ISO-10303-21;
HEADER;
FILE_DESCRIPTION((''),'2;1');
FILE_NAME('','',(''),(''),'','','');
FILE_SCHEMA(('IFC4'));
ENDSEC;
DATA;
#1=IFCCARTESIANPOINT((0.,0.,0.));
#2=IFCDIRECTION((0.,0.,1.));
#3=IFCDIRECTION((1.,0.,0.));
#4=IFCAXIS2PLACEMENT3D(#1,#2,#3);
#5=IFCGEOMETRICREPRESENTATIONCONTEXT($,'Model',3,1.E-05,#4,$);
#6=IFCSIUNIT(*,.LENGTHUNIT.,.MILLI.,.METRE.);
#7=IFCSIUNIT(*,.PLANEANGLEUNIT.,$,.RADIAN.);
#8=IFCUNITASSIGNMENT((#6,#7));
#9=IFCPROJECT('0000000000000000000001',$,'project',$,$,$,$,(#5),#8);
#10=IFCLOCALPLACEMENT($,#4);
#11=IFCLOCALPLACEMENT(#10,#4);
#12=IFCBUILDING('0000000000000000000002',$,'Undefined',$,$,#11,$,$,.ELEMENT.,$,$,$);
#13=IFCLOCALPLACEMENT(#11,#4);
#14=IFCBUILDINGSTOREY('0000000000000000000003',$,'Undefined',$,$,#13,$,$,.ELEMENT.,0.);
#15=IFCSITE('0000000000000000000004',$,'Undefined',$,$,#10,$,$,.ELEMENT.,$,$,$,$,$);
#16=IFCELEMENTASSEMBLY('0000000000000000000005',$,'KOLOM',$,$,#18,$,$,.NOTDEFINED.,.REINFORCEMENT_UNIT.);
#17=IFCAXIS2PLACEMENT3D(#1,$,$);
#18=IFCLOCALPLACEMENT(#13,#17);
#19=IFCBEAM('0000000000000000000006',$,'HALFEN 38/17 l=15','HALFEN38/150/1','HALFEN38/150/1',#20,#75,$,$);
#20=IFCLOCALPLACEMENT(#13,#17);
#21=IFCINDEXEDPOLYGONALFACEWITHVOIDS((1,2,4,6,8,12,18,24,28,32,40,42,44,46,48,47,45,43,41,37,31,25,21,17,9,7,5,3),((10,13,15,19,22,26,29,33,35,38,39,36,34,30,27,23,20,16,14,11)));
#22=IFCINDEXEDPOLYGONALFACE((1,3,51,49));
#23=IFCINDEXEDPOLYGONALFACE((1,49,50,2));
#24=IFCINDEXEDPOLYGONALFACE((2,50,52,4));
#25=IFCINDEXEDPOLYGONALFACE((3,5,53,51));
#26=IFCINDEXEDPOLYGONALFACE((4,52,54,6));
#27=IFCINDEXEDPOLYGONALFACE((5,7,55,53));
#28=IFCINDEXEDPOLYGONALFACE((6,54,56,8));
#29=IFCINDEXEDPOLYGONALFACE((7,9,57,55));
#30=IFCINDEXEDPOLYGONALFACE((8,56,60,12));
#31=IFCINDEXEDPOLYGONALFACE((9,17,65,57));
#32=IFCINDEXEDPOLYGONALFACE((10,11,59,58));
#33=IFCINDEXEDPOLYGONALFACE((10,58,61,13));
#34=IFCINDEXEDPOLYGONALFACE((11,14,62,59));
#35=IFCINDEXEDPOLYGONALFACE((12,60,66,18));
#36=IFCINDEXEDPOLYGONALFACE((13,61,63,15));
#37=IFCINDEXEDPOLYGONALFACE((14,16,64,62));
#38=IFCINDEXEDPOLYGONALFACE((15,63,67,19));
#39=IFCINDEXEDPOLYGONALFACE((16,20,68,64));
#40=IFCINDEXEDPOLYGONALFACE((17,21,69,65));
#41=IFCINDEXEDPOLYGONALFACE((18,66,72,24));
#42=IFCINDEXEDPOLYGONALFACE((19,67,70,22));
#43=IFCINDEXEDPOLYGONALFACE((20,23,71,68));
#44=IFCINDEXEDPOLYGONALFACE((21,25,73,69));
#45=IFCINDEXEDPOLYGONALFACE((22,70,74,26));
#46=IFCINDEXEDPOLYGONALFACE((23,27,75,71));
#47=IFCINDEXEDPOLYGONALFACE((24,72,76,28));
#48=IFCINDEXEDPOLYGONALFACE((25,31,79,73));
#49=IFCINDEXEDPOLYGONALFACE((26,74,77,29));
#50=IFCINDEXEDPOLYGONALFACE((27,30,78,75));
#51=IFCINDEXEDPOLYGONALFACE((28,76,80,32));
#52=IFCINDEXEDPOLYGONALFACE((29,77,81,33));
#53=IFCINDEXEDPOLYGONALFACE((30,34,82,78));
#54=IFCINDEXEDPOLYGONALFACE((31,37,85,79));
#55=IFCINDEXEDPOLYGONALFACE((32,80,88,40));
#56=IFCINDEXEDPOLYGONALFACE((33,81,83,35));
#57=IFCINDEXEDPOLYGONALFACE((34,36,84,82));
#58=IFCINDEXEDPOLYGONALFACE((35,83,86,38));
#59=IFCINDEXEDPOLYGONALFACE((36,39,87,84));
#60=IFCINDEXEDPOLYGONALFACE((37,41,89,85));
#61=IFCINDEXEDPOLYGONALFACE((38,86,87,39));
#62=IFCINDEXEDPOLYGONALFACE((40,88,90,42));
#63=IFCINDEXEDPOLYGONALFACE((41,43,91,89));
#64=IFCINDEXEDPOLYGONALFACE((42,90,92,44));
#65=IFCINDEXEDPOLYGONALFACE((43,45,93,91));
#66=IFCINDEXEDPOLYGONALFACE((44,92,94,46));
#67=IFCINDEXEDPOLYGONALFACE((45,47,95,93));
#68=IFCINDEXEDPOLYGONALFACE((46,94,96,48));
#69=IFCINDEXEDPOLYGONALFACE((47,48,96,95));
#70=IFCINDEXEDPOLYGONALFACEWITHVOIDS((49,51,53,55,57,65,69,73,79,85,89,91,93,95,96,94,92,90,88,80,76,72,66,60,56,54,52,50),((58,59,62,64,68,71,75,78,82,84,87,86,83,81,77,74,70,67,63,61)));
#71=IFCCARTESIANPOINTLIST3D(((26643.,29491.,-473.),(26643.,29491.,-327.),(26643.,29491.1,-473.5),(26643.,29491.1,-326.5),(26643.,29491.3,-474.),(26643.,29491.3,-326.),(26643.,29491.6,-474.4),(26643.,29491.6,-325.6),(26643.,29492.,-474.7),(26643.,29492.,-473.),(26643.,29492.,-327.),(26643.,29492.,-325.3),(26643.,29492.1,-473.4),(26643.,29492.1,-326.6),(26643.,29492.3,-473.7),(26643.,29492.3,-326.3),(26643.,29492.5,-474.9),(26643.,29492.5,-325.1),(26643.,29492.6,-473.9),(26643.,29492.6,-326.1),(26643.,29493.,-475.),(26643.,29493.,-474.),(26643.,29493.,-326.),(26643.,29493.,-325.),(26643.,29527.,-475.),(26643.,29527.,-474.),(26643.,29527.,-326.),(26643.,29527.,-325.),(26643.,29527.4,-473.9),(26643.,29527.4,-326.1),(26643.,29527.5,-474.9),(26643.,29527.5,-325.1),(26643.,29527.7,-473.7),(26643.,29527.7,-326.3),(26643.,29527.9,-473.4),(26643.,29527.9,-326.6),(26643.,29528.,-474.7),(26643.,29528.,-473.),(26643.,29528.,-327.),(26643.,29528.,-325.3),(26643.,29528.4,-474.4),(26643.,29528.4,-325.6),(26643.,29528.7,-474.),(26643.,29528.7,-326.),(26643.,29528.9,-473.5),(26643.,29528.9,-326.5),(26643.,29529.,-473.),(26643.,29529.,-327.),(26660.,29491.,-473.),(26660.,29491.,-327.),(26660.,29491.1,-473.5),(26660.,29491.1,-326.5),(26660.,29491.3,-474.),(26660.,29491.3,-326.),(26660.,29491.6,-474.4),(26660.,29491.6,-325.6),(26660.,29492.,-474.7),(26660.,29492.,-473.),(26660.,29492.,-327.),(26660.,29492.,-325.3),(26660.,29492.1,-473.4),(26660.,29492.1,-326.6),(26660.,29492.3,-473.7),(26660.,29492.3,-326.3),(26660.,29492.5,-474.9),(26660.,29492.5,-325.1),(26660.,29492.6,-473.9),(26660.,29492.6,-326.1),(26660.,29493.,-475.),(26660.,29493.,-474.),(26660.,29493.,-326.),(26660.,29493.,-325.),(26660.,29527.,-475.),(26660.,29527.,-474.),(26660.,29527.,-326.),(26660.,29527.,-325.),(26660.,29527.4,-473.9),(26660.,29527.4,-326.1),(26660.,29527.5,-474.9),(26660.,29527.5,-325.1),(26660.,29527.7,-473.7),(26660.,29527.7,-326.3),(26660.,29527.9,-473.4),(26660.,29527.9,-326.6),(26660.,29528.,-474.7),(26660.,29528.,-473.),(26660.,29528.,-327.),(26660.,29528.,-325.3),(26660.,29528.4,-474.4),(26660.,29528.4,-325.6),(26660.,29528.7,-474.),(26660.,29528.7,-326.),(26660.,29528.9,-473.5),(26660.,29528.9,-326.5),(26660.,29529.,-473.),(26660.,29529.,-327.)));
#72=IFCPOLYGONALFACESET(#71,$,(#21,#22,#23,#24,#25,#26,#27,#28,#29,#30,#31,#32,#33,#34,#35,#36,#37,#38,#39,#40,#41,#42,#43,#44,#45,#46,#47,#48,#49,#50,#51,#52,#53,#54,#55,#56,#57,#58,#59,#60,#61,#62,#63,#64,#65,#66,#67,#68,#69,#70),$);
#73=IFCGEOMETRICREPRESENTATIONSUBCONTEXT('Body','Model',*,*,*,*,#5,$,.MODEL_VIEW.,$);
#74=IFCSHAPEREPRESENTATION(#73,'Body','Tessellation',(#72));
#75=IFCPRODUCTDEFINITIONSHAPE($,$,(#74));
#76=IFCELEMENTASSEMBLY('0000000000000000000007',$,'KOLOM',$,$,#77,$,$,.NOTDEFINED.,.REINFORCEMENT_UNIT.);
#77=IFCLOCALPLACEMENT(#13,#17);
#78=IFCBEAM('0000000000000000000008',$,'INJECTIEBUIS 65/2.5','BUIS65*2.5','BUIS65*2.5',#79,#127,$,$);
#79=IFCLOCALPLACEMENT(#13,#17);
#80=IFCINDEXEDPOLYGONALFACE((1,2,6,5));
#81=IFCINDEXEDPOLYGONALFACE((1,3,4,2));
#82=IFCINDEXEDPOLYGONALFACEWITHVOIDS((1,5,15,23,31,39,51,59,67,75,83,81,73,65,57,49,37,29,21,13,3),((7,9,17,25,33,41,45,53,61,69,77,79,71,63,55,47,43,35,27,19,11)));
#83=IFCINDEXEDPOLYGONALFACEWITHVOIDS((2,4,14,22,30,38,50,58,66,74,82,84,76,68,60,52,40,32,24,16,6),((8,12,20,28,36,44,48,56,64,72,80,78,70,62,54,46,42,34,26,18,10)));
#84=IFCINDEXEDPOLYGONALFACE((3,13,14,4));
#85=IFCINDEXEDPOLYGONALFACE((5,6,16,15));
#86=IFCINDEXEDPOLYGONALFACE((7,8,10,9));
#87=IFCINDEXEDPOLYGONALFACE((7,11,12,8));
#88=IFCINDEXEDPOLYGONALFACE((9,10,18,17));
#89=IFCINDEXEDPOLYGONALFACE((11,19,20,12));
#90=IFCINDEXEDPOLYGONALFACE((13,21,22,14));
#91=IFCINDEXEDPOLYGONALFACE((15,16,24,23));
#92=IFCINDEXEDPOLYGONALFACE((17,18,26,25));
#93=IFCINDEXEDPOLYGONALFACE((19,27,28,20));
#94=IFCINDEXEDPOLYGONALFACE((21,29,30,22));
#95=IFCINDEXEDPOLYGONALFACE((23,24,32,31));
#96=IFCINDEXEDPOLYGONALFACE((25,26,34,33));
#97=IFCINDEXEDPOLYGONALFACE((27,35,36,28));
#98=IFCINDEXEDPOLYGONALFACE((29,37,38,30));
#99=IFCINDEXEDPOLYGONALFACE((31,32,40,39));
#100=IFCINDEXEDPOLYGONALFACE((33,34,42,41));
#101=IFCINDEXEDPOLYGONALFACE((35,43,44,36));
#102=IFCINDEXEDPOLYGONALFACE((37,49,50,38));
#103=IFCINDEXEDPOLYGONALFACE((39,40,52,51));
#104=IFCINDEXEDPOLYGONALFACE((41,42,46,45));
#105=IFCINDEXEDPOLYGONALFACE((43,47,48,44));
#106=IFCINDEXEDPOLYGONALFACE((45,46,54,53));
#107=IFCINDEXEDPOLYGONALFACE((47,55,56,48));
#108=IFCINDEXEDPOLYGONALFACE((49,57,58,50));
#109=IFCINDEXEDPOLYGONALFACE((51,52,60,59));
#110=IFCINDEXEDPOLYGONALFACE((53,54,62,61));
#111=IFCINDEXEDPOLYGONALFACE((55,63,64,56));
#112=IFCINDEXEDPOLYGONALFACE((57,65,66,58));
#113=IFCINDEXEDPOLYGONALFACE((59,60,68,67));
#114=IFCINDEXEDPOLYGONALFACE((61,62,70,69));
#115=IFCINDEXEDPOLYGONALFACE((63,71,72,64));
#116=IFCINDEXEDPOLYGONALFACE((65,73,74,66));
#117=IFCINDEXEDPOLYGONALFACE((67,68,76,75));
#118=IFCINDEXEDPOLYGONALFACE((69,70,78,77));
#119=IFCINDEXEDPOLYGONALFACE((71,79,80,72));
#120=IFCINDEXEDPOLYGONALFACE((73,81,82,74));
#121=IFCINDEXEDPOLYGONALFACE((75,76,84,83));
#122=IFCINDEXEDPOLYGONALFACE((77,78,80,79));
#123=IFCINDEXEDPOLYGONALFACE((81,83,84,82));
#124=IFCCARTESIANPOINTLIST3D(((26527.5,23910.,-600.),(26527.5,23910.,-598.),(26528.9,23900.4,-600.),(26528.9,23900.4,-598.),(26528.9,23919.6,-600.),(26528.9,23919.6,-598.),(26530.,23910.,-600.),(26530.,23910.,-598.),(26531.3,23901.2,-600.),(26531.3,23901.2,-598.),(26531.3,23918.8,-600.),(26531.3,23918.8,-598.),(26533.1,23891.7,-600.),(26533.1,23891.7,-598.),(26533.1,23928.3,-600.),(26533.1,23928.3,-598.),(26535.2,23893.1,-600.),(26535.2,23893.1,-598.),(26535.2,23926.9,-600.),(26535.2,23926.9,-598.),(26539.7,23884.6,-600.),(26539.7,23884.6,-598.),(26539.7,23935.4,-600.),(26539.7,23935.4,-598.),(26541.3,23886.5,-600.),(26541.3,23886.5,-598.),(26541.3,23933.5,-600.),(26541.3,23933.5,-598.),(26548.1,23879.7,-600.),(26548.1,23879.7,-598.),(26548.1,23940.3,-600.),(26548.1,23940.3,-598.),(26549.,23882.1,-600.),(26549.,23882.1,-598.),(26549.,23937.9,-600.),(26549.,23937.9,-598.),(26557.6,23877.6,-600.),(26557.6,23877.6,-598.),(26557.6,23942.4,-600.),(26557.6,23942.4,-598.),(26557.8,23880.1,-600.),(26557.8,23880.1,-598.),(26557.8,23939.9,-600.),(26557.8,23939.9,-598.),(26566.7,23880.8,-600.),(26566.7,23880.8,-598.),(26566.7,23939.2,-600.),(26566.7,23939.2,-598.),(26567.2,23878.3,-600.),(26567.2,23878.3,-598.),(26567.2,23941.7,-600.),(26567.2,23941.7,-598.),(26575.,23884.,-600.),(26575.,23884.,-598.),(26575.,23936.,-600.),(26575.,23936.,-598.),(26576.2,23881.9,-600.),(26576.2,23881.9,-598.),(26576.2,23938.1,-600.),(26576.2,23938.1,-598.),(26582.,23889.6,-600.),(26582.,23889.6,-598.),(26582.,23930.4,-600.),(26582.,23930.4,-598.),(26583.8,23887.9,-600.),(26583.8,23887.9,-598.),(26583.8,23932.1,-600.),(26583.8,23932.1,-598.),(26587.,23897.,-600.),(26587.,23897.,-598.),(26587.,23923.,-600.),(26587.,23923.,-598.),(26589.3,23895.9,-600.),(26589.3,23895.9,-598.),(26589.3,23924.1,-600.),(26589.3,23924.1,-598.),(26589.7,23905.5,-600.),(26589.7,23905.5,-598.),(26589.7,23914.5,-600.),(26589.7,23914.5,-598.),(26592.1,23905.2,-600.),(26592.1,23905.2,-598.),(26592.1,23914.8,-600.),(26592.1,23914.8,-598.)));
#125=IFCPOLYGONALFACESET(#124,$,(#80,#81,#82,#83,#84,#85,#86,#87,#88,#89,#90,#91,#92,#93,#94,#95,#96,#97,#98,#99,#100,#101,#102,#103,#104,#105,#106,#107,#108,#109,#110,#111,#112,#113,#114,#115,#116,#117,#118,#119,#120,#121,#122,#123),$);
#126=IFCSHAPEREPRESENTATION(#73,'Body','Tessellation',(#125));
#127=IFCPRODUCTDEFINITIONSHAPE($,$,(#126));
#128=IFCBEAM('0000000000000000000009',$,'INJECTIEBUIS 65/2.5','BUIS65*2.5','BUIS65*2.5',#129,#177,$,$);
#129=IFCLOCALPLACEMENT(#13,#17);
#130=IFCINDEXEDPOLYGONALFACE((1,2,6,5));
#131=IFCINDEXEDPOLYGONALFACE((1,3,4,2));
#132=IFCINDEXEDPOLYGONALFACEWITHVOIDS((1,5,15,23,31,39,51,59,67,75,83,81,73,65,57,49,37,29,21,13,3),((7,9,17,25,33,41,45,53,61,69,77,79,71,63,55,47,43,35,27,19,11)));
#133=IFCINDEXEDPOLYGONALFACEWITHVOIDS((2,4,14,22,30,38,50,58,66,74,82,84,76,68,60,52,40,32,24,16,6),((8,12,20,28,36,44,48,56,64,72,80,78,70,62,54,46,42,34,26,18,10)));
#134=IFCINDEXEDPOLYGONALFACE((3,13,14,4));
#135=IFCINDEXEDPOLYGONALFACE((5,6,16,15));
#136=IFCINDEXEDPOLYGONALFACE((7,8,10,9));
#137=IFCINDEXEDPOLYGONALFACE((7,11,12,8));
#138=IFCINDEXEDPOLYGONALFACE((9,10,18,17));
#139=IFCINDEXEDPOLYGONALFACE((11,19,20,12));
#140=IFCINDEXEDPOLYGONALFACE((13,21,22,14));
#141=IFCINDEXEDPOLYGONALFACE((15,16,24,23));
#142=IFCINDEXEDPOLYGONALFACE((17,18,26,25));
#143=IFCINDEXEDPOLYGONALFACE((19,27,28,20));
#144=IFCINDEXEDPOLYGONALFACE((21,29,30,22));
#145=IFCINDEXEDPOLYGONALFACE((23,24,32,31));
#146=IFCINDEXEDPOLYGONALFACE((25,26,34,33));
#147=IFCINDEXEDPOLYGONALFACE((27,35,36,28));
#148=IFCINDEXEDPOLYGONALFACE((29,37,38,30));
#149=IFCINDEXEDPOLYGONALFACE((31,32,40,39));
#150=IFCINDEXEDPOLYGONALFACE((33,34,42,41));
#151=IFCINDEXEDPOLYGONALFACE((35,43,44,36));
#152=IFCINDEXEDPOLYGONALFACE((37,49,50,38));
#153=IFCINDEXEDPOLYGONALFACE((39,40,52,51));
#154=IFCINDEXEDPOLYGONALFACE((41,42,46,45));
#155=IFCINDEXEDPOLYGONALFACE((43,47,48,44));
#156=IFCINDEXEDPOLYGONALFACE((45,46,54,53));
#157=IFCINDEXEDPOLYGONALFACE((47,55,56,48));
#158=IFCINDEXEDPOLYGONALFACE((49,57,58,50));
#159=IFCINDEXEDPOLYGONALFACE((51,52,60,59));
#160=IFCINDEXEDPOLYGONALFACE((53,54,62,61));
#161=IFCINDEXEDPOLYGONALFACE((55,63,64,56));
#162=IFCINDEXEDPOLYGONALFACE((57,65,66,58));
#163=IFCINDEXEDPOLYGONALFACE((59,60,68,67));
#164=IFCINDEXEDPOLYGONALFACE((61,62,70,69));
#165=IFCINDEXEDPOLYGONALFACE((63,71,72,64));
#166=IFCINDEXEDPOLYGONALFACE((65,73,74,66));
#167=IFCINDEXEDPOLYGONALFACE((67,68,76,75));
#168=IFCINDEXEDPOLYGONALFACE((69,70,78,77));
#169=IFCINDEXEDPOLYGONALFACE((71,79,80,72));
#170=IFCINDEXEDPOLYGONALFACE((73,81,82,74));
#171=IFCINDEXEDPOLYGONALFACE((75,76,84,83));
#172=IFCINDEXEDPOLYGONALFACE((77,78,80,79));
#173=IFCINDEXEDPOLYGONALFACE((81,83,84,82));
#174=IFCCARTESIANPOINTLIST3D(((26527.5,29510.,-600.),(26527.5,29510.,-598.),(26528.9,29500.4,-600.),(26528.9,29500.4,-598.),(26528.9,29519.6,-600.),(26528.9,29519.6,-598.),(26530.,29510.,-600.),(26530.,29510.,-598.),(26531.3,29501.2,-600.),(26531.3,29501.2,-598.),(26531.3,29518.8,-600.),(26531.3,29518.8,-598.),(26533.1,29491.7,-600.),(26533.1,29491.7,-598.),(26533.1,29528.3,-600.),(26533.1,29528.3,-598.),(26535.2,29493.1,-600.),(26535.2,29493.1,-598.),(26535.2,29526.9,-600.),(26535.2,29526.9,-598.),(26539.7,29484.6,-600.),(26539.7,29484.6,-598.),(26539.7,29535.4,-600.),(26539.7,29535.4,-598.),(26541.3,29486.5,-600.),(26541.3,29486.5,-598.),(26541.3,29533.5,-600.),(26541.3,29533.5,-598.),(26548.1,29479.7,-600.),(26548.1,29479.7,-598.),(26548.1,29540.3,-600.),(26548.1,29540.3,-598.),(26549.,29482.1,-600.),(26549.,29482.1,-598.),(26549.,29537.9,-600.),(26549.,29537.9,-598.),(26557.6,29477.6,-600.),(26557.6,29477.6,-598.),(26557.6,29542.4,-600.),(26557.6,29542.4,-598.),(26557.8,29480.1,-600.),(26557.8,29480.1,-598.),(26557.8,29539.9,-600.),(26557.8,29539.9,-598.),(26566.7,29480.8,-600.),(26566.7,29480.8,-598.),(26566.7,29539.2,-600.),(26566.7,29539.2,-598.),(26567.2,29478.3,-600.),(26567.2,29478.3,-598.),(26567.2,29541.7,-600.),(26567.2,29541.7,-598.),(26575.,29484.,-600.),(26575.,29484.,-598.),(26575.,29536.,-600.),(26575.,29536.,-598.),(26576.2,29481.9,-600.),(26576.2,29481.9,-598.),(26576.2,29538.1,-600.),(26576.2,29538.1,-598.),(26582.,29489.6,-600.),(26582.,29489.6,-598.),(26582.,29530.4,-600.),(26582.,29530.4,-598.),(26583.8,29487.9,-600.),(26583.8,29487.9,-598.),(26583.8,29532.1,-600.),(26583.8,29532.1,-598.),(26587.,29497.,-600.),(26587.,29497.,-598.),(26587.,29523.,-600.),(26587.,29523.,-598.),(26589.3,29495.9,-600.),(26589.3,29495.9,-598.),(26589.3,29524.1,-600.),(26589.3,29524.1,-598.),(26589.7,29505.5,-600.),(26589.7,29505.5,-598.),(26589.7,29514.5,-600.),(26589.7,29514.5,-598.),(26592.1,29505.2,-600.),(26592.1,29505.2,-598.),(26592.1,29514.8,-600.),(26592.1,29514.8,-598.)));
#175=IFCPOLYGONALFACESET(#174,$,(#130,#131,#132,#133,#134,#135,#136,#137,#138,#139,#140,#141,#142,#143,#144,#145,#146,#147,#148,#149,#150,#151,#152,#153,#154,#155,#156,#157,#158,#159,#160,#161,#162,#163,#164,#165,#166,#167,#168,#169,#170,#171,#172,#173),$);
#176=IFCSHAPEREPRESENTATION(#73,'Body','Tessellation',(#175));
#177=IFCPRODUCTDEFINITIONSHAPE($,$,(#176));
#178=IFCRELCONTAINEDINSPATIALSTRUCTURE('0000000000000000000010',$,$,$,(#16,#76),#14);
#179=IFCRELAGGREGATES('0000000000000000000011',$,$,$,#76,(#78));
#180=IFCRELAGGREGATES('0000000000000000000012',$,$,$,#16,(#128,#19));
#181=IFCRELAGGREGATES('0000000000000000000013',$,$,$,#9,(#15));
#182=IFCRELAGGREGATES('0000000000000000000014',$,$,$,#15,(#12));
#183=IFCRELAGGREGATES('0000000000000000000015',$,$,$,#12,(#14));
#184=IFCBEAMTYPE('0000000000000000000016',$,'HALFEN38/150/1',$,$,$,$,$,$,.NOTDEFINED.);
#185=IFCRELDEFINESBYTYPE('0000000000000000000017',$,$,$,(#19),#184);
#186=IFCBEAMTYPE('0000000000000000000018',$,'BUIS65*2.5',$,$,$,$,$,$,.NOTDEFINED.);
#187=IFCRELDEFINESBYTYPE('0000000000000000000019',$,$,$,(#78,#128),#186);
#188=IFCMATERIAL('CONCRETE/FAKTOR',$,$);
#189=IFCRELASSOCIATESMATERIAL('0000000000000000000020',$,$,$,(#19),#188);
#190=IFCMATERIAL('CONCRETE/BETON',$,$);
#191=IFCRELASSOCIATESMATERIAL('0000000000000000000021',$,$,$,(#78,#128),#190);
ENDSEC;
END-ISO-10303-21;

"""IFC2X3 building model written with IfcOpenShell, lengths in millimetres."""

from ifc_helpers import new_model, si_unit, frame, frame_2d, origin_with_axes, place, context, subcontext, project, spatial, hollow_rectangle, hollow_circle, extrude, material, type_object, element, aggregate, save


model = new_model("IFC2X3")

# Units and contexts
model_context = context("Model", 3, precision=1e-05, world=origin_with_axes())
body_context = subcontext(model_context, "Body", "Model", "MODEL_VIEW")
ifc_project = project(units=[si_unit("LENGTHUNIT", "METRE", prefix="MILLI"), si_unit("PLANEANGLEUNIT", "RADIAN")], contexts=[model_context])

# Site, building, storey
site_placement = place(None, origin_with_axes())
site = spatial("IfcSite", under=ifc_project, at=site_placement, Name="Undefined", CompositionType="ELEMENT")
building_placement = place(site_placement, origin_with_axes())
building = spatial("IfcBuilding", under=site, at=building_placement, Name="Undefined", CompositionType="ELEMENT")
storey_placement = place(building_placement, origin_with_axes())
storey = spatial("IfcBuildingStorey", under=building, at=storey_placement, Name="Undefined", CompositionType="ELEMENT", Elevation=0.0)

# Shared definitions
ifc_material_1 = material(Name="CONCRETE/BETON")
ifc_material_2 = material(Name="CONCRETE/FAKTOR")

# Element assembly
beam_type_1 = type_object("IfcBeamType", Name="HALFEN38/150/1", PredefinedType="NOTDEFINED")
assembly_1_placement = place(storey_placement, origin_with_axes())
assembly_1 = element("IfcElementAssembly", 1, at=assembly_1_placement, inside=storey, Name="KOLOM", AssemblyPlace="NOTDEFINED", PredefinedType="REINFORCEMENT_UNIT")

# Beam
beam_1_placement = place(assembly_1_placement, frame((26660.0, 29510.0, -400.0), z_axis=(0.0, -1.0, 0.0), x_axis=(-1.0, 0.0, 0.0)))
beam_1 = element("IfcBeam", 2, at=beam_1_placement, type_object=beam_type_1, material=ifc_material_2, Name="HALFEN 38/17 l=15", Description="HALFEN38/150/1", ObjectType="HALFEN38/150/1", context=body_context, shape_type="SweptSolid", body=[
    extrude(hollow_rectangle(XDim=150.0, YDim=38.0, WallThickness=1.0, InnerFilletRadius=1.0, OuterFilletRadius=2.0, at=frame_2d((0.0, 0.0), x_axis=(1.0, 0.0))), frame((17.0, 0.0, 0.0), z_axis=(-1.0, 0.0, 0.0), x_axis=(0.0, -1.0, 0.0)), (0.0, 0.0, 1.0), 17.0),
])

# Element assembly, beam
assembly_2_placement = place(storey_placement, origin_with_axes())
assembly_2 = element("IfcElementAssembly", 3, at=assembly_2_placement, inside=storey, Name="KOLOM", AssemblyPlace="NOTDEFINED", PredefinedType="REINFORCEMENT_UNIT")
beam_type_2 = type_object("IfcBeamType", Name="BUIS65*2.5", PredefinedType="NOTDEFINED")
beam_2_placement = place(assembly_2_placement, frame((26560.0, 23910.0, -600.0), z_axis=(0.0, 1.0, 0.0), x_axis=(0.0, 0.0, 1.0)))
beam_2 = element("IfcBeam", 4, at=beam_2_placement, type_object=beam_type_2, material=ifc_material_1, Name="INJECTIEBUIS 65/2.5", Description="BUIS65*2.5", ObjectType="BUIS65*2.5", context=body_context, shape_type="SweptSolid", body=[
    extrude(hollow_circle(Radius=32.5, WallThickness=2.5, at=frame_2d((0.0, 0.0), x_axis=(1.0, 0.0))), frame((2.0, 0.0, 0.0), z_axis=(-1.0, 0.0, 0.0), x_axis=(0.0, -1.0, 0.0)), (0.0, 0.0, 1.0), 2.0),
])
aggregate(assembly_2, [beam_2])

# Beam
beam_3_placement = place(assembly_1_placement, frame((26560.0, 29510.0, -600.0), z_axis=(0.0, 1.0, 0.0), x_axis=(0.0, 0.0, 1.0)))
beam_3 = element("IfcBeam", 5, at=beam_3_placement, type_object=beam_type_2, material=ifc_material_1, Name="INJECTIEBUIS 65/2.5", Description="BUIS65*2.5", ObjectType="BUIS65*2.5", context=body_context, shape_type="SweptSolid", body=[
    extrude(hollow_circle(Radius=32.5, WallThickness=2.5, at=frame_2d((0.0, 0.0), x_axis=(1.0, 0.0))), frame((2.0, 0.0, 0.0), z_axis=(-1.0, 0.0, 0.0), x_axis=(0.0, -1.0, 0.0)), (0.0, 0.0, 1.0), 2.0),
])

aggregate(assembly_1, [beam_3, beam_1])

save(model, "model.ifc")
